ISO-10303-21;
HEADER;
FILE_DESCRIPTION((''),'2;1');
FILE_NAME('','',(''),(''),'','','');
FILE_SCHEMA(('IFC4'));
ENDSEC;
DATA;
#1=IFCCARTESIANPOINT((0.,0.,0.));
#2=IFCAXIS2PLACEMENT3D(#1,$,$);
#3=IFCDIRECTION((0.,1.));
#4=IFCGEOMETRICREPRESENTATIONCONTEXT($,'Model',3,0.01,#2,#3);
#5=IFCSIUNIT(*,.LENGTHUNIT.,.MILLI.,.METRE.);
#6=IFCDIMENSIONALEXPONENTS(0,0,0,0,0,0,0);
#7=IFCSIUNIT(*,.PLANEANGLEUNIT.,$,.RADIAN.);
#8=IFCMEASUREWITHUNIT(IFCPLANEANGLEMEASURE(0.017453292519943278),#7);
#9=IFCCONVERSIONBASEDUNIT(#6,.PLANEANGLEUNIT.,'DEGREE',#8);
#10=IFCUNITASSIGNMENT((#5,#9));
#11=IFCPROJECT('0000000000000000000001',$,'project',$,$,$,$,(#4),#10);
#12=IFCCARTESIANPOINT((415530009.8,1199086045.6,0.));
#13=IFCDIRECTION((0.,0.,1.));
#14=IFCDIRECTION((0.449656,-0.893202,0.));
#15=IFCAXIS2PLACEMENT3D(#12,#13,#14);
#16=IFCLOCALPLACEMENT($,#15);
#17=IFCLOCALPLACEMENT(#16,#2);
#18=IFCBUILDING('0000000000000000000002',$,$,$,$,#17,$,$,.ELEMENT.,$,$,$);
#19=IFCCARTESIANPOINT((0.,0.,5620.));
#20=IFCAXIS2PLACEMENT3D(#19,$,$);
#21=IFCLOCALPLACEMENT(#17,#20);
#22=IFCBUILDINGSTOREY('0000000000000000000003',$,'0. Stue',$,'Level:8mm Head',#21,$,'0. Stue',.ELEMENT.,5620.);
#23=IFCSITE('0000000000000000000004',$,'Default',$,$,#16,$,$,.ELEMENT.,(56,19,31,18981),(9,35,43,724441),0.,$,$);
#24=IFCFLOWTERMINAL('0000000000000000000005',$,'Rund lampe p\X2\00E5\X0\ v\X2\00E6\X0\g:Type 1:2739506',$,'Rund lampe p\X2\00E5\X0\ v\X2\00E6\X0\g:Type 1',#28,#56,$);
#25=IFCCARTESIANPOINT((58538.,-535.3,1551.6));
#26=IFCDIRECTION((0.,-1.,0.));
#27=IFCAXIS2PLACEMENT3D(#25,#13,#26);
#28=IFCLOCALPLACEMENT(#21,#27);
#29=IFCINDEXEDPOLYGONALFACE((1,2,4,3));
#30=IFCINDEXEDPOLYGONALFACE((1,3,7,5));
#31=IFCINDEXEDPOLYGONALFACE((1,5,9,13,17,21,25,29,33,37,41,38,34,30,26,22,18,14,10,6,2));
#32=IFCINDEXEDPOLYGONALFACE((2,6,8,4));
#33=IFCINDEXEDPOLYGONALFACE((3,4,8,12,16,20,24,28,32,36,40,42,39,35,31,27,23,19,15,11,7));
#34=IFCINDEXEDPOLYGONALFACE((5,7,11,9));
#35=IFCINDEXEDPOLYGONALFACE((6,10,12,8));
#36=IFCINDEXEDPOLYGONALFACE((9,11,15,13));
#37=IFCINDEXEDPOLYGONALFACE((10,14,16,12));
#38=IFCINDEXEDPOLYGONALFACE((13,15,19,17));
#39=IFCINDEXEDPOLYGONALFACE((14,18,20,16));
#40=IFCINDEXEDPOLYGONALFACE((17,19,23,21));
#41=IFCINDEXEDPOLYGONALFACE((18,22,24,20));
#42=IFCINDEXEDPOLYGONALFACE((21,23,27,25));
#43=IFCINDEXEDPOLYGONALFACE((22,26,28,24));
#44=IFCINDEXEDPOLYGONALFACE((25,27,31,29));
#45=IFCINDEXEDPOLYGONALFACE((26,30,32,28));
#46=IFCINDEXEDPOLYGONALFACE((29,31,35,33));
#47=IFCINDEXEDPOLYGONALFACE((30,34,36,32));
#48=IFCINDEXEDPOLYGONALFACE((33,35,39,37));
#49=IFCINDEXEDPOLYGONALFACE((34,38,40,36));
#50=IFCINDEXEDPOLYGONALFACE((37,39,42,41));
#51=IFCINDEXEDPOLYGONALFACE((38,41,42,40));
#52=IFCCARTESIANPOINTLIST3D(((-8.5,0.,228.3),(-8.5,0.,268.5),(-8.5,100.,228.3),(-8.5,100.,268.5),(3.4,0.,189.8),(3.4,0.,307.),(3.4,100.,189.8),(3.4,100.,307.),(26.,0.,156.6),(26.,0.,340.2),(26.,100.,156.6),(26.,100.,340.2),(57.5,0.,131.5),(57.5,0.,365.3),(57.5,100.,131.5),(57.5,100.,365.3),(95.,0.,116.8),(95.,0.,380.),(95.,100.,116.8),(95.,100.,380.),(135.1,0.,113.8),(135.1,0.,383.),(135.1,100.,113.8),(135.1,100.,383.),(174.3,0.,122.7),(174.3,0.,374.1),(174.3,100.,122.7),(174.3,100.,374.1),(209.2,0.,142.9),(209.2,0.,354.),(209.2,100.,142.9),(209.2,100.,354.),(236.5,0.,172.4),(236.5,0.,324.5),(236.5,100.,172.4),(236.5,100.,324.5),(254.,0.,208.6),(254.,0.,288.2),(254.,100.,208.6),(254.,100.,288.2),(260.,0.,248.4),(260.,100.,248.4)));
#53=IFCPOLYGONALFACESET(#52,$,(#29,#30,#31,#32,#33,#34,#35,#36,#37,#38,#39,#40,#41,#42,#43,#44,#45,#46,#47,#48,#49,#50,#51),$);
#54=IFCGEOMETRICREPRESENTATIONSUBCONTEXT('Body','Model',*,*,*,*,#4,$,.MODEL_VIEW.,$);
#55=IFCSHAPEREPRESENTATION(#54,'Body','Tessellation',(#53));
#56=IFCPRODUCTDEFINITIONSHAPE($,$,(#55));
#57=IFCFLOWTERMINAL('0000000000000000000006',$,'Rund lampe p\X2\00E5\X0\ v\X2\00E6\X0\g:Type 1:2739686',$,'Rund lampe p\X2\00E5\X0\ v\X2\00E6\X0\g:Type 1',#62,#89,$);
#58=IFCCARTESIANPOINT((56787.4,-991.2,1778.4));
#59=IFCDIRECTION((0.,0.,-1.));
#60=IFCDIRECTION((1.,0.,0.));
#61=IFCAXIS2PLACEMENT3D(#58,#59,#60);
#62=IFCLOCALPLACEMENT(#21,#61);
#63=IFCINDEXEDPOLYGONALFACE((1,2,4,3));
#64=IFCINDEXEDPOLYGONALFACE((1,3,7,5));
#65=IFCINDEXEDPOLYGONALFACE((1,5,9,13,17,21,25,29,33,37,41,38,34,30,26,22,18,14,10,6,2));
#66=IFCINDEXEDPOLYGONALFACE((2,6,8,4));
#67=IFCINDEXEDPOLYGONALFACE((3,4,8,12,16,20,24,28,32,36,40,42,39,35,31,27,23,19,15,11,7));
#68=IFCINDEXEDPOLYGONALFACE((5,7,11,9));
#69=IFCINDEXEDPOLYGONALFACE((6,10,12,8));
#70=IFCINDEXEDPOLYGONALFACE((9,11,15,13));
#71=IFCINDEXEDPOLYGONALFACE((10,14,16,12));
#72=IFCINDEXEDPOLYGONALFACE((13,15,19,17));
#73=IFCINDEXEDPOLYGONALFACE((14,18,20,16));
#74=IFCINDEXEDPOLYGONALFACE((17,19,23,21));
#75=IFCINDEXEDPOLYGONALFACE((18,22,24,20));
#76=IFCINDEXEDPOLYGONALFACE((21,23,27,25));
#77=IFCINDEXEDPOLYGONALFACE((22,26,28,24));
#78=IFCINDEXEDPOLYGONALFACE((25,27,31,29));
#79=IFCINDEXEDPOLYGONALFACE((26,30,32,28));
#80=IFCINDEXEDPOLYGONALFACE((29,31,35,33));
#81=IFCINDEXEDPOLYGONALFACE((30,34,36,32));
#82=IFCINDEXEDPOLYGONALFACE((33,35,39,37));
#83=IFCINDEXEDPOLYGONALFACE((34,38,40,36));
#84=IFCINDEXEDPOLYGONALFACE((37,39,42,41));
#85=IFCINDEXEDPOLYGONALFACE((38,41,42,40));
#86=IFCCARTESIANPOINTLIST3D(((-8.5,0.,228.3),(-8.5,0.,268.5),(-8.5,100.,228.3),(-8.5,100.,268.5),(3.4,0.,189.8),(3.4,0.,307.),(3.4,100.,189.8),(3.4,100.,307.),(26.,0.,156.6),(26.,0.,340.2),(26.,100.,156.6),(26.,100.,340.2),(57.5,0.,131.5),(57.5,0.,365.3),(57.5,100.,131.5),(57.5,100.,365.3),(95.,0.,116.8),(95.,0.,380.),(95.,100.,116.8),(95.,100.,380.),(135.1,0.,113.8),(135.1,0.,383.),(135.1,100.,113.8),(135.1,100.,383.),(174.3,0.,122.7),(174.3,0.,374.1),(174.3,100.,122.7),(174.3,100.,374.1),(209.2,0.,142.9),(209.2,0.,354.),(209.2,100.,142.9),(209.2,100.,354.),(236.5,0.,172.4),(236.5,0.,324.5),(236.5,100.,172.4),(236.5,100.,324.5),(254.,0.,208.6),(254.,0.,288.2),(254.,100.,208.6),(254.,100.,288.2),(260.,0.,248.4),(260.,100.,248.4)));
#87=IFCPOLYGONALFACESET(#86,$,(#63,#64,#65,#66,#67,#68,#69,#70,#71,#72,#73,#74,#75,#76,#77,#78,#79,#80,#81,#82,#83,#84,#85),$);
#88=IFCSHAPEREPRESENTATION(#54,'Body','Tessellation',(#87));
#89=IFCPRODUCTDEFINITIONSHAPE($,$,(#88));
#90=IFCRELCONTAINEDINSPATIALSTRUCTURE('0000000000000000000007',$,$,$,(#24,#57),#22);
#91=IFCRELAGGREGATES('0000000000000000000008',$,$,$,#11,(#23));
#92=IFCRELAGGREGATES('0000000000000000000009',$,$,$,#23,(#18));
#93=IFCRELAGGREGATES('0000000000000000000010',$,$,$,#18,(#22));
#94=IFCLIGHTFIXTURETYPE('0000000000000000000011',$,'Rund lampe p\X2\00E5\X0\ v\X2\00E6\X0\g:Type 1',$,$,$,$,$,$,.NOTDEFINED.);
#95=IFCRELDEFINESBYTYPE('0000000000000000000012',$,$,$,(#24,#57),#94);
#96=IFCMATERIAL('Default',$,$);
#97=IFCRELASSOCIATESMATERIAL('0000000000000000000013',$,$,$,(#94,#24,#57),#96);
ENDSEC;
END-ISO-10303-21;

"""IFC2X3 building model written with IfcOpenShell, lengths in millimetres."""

from ifc_helpers import new_model, entity, si_unit, converted_unit, direction, frame, frame_2d, origin, place, context, subcontext, project, spatial, circle, extrude, source, transform, mapped, material, type_object, type_shapes, element, save


model = new_model("IFC2X3")

# Units and contexts
model_context = context("Model", 3, precision=0.01, world=origin(), true_north=direction((0.0, 1.0)))
body_context = subcontext(model_context, "Body", "Model", "MODEL_VIEW")
ifc_project = project(units=[si_unit("LENGTHUNIT", "METRE", prefix="MILLI"), converted_unit("PLANEANGLEUNIT", "DEGREE", entity("IfcPlaneAngleMeasure", 0.017453292519943278), si_unit("PLANEANGLEUNIT", "RADIAN"), dimensions=[0, 0, 0, 0, 0, 0, 0])], contexts=[model_context])

# Site, building, storey
site_placement = place(None, frame((415530009.8, 1199086045.6, 0.0), z_axis=(0.0, 0.0, 1.0), x_axis=(0.449656, -0.893202, 0.0)))
site = spatial("IfcSite", under=ifc_project, at=site_placement, Name="Default", CompositionType="ELEMENT", RefLatitude=(56, 19, 31, 18981), RefLongitude=(9, 35, 43, 724441), RefElevation=0.0)
building_placement = place(site_placement, origin())
building = spatial("IfcBuilding", under=site, at=building_placement, CompositionType="ELEMENT")
storey_placement = place(building_placement, frame((0.0, 0.0, 5620.0)))
storey = spatial("IfcBuildingStorey", under=building, at=storey_placement, Name="0. Stue", ObjectType="Level:8mm Head", LongName="0. Stue", CompositionType="ELEMENT", Elevation=5620.0)

# Flow terminals
ifc_material_1 = material(Name="Default")
light_fixture_type_1 = type_object("IfcLightFixtureType", Name="Rund lampe på væg:Type 1", PredefinedType="NOTDEFINED", material=ifc_material_1)
shared_shape_1 = source(origin(), body_context, "Body", "SweptSolid", [
    extrude(circle(Radius=135.0, at=frame_2d((0.0, 0.0), x_axis=(1.0, 0.0))), frame((125.0, 0.0, 248.4), z_axis=(0.0, 1.0, 0.0), x_axis=(1.0, 0.0, 0.0)), (0.0, 0.0, 1.0), 100.0),
])
type_shapes(light_fixture_type_1, [shared_shape_1])
for number, where, z_axis, x_axis, name in (
    (1, (58538.0, -535.3, 1551.6), (0.0, 0.0, 1.0), (0.0, -1.0, 0.0), "Rund lampe på væg:Type 1:2739506"),
    (2, (56787.4, -991.2, 1778.4), (0.0, 0.0, -1.0), (1.0, 0.0, 0.0), "Rund lampe på væg:Type 1:2739686"),
):
    element("IfcFlowTerminal", number, at=place(storey_placement, frame(where, z_axis=z_axis, x_axis=x_axis)), inside=storey, type_object=light_fixture_type_1, material=ifc_material_1, Name=name, ObjectType="Rund lampe på væg:Type 1", context=body_context, shape_type="MappedRepresentation", body=[
        mapped(shared_shape_1, transform((0.0, 0.0, 0.0), scale=1.0)),
    ])

save(model, "model.ifc")
